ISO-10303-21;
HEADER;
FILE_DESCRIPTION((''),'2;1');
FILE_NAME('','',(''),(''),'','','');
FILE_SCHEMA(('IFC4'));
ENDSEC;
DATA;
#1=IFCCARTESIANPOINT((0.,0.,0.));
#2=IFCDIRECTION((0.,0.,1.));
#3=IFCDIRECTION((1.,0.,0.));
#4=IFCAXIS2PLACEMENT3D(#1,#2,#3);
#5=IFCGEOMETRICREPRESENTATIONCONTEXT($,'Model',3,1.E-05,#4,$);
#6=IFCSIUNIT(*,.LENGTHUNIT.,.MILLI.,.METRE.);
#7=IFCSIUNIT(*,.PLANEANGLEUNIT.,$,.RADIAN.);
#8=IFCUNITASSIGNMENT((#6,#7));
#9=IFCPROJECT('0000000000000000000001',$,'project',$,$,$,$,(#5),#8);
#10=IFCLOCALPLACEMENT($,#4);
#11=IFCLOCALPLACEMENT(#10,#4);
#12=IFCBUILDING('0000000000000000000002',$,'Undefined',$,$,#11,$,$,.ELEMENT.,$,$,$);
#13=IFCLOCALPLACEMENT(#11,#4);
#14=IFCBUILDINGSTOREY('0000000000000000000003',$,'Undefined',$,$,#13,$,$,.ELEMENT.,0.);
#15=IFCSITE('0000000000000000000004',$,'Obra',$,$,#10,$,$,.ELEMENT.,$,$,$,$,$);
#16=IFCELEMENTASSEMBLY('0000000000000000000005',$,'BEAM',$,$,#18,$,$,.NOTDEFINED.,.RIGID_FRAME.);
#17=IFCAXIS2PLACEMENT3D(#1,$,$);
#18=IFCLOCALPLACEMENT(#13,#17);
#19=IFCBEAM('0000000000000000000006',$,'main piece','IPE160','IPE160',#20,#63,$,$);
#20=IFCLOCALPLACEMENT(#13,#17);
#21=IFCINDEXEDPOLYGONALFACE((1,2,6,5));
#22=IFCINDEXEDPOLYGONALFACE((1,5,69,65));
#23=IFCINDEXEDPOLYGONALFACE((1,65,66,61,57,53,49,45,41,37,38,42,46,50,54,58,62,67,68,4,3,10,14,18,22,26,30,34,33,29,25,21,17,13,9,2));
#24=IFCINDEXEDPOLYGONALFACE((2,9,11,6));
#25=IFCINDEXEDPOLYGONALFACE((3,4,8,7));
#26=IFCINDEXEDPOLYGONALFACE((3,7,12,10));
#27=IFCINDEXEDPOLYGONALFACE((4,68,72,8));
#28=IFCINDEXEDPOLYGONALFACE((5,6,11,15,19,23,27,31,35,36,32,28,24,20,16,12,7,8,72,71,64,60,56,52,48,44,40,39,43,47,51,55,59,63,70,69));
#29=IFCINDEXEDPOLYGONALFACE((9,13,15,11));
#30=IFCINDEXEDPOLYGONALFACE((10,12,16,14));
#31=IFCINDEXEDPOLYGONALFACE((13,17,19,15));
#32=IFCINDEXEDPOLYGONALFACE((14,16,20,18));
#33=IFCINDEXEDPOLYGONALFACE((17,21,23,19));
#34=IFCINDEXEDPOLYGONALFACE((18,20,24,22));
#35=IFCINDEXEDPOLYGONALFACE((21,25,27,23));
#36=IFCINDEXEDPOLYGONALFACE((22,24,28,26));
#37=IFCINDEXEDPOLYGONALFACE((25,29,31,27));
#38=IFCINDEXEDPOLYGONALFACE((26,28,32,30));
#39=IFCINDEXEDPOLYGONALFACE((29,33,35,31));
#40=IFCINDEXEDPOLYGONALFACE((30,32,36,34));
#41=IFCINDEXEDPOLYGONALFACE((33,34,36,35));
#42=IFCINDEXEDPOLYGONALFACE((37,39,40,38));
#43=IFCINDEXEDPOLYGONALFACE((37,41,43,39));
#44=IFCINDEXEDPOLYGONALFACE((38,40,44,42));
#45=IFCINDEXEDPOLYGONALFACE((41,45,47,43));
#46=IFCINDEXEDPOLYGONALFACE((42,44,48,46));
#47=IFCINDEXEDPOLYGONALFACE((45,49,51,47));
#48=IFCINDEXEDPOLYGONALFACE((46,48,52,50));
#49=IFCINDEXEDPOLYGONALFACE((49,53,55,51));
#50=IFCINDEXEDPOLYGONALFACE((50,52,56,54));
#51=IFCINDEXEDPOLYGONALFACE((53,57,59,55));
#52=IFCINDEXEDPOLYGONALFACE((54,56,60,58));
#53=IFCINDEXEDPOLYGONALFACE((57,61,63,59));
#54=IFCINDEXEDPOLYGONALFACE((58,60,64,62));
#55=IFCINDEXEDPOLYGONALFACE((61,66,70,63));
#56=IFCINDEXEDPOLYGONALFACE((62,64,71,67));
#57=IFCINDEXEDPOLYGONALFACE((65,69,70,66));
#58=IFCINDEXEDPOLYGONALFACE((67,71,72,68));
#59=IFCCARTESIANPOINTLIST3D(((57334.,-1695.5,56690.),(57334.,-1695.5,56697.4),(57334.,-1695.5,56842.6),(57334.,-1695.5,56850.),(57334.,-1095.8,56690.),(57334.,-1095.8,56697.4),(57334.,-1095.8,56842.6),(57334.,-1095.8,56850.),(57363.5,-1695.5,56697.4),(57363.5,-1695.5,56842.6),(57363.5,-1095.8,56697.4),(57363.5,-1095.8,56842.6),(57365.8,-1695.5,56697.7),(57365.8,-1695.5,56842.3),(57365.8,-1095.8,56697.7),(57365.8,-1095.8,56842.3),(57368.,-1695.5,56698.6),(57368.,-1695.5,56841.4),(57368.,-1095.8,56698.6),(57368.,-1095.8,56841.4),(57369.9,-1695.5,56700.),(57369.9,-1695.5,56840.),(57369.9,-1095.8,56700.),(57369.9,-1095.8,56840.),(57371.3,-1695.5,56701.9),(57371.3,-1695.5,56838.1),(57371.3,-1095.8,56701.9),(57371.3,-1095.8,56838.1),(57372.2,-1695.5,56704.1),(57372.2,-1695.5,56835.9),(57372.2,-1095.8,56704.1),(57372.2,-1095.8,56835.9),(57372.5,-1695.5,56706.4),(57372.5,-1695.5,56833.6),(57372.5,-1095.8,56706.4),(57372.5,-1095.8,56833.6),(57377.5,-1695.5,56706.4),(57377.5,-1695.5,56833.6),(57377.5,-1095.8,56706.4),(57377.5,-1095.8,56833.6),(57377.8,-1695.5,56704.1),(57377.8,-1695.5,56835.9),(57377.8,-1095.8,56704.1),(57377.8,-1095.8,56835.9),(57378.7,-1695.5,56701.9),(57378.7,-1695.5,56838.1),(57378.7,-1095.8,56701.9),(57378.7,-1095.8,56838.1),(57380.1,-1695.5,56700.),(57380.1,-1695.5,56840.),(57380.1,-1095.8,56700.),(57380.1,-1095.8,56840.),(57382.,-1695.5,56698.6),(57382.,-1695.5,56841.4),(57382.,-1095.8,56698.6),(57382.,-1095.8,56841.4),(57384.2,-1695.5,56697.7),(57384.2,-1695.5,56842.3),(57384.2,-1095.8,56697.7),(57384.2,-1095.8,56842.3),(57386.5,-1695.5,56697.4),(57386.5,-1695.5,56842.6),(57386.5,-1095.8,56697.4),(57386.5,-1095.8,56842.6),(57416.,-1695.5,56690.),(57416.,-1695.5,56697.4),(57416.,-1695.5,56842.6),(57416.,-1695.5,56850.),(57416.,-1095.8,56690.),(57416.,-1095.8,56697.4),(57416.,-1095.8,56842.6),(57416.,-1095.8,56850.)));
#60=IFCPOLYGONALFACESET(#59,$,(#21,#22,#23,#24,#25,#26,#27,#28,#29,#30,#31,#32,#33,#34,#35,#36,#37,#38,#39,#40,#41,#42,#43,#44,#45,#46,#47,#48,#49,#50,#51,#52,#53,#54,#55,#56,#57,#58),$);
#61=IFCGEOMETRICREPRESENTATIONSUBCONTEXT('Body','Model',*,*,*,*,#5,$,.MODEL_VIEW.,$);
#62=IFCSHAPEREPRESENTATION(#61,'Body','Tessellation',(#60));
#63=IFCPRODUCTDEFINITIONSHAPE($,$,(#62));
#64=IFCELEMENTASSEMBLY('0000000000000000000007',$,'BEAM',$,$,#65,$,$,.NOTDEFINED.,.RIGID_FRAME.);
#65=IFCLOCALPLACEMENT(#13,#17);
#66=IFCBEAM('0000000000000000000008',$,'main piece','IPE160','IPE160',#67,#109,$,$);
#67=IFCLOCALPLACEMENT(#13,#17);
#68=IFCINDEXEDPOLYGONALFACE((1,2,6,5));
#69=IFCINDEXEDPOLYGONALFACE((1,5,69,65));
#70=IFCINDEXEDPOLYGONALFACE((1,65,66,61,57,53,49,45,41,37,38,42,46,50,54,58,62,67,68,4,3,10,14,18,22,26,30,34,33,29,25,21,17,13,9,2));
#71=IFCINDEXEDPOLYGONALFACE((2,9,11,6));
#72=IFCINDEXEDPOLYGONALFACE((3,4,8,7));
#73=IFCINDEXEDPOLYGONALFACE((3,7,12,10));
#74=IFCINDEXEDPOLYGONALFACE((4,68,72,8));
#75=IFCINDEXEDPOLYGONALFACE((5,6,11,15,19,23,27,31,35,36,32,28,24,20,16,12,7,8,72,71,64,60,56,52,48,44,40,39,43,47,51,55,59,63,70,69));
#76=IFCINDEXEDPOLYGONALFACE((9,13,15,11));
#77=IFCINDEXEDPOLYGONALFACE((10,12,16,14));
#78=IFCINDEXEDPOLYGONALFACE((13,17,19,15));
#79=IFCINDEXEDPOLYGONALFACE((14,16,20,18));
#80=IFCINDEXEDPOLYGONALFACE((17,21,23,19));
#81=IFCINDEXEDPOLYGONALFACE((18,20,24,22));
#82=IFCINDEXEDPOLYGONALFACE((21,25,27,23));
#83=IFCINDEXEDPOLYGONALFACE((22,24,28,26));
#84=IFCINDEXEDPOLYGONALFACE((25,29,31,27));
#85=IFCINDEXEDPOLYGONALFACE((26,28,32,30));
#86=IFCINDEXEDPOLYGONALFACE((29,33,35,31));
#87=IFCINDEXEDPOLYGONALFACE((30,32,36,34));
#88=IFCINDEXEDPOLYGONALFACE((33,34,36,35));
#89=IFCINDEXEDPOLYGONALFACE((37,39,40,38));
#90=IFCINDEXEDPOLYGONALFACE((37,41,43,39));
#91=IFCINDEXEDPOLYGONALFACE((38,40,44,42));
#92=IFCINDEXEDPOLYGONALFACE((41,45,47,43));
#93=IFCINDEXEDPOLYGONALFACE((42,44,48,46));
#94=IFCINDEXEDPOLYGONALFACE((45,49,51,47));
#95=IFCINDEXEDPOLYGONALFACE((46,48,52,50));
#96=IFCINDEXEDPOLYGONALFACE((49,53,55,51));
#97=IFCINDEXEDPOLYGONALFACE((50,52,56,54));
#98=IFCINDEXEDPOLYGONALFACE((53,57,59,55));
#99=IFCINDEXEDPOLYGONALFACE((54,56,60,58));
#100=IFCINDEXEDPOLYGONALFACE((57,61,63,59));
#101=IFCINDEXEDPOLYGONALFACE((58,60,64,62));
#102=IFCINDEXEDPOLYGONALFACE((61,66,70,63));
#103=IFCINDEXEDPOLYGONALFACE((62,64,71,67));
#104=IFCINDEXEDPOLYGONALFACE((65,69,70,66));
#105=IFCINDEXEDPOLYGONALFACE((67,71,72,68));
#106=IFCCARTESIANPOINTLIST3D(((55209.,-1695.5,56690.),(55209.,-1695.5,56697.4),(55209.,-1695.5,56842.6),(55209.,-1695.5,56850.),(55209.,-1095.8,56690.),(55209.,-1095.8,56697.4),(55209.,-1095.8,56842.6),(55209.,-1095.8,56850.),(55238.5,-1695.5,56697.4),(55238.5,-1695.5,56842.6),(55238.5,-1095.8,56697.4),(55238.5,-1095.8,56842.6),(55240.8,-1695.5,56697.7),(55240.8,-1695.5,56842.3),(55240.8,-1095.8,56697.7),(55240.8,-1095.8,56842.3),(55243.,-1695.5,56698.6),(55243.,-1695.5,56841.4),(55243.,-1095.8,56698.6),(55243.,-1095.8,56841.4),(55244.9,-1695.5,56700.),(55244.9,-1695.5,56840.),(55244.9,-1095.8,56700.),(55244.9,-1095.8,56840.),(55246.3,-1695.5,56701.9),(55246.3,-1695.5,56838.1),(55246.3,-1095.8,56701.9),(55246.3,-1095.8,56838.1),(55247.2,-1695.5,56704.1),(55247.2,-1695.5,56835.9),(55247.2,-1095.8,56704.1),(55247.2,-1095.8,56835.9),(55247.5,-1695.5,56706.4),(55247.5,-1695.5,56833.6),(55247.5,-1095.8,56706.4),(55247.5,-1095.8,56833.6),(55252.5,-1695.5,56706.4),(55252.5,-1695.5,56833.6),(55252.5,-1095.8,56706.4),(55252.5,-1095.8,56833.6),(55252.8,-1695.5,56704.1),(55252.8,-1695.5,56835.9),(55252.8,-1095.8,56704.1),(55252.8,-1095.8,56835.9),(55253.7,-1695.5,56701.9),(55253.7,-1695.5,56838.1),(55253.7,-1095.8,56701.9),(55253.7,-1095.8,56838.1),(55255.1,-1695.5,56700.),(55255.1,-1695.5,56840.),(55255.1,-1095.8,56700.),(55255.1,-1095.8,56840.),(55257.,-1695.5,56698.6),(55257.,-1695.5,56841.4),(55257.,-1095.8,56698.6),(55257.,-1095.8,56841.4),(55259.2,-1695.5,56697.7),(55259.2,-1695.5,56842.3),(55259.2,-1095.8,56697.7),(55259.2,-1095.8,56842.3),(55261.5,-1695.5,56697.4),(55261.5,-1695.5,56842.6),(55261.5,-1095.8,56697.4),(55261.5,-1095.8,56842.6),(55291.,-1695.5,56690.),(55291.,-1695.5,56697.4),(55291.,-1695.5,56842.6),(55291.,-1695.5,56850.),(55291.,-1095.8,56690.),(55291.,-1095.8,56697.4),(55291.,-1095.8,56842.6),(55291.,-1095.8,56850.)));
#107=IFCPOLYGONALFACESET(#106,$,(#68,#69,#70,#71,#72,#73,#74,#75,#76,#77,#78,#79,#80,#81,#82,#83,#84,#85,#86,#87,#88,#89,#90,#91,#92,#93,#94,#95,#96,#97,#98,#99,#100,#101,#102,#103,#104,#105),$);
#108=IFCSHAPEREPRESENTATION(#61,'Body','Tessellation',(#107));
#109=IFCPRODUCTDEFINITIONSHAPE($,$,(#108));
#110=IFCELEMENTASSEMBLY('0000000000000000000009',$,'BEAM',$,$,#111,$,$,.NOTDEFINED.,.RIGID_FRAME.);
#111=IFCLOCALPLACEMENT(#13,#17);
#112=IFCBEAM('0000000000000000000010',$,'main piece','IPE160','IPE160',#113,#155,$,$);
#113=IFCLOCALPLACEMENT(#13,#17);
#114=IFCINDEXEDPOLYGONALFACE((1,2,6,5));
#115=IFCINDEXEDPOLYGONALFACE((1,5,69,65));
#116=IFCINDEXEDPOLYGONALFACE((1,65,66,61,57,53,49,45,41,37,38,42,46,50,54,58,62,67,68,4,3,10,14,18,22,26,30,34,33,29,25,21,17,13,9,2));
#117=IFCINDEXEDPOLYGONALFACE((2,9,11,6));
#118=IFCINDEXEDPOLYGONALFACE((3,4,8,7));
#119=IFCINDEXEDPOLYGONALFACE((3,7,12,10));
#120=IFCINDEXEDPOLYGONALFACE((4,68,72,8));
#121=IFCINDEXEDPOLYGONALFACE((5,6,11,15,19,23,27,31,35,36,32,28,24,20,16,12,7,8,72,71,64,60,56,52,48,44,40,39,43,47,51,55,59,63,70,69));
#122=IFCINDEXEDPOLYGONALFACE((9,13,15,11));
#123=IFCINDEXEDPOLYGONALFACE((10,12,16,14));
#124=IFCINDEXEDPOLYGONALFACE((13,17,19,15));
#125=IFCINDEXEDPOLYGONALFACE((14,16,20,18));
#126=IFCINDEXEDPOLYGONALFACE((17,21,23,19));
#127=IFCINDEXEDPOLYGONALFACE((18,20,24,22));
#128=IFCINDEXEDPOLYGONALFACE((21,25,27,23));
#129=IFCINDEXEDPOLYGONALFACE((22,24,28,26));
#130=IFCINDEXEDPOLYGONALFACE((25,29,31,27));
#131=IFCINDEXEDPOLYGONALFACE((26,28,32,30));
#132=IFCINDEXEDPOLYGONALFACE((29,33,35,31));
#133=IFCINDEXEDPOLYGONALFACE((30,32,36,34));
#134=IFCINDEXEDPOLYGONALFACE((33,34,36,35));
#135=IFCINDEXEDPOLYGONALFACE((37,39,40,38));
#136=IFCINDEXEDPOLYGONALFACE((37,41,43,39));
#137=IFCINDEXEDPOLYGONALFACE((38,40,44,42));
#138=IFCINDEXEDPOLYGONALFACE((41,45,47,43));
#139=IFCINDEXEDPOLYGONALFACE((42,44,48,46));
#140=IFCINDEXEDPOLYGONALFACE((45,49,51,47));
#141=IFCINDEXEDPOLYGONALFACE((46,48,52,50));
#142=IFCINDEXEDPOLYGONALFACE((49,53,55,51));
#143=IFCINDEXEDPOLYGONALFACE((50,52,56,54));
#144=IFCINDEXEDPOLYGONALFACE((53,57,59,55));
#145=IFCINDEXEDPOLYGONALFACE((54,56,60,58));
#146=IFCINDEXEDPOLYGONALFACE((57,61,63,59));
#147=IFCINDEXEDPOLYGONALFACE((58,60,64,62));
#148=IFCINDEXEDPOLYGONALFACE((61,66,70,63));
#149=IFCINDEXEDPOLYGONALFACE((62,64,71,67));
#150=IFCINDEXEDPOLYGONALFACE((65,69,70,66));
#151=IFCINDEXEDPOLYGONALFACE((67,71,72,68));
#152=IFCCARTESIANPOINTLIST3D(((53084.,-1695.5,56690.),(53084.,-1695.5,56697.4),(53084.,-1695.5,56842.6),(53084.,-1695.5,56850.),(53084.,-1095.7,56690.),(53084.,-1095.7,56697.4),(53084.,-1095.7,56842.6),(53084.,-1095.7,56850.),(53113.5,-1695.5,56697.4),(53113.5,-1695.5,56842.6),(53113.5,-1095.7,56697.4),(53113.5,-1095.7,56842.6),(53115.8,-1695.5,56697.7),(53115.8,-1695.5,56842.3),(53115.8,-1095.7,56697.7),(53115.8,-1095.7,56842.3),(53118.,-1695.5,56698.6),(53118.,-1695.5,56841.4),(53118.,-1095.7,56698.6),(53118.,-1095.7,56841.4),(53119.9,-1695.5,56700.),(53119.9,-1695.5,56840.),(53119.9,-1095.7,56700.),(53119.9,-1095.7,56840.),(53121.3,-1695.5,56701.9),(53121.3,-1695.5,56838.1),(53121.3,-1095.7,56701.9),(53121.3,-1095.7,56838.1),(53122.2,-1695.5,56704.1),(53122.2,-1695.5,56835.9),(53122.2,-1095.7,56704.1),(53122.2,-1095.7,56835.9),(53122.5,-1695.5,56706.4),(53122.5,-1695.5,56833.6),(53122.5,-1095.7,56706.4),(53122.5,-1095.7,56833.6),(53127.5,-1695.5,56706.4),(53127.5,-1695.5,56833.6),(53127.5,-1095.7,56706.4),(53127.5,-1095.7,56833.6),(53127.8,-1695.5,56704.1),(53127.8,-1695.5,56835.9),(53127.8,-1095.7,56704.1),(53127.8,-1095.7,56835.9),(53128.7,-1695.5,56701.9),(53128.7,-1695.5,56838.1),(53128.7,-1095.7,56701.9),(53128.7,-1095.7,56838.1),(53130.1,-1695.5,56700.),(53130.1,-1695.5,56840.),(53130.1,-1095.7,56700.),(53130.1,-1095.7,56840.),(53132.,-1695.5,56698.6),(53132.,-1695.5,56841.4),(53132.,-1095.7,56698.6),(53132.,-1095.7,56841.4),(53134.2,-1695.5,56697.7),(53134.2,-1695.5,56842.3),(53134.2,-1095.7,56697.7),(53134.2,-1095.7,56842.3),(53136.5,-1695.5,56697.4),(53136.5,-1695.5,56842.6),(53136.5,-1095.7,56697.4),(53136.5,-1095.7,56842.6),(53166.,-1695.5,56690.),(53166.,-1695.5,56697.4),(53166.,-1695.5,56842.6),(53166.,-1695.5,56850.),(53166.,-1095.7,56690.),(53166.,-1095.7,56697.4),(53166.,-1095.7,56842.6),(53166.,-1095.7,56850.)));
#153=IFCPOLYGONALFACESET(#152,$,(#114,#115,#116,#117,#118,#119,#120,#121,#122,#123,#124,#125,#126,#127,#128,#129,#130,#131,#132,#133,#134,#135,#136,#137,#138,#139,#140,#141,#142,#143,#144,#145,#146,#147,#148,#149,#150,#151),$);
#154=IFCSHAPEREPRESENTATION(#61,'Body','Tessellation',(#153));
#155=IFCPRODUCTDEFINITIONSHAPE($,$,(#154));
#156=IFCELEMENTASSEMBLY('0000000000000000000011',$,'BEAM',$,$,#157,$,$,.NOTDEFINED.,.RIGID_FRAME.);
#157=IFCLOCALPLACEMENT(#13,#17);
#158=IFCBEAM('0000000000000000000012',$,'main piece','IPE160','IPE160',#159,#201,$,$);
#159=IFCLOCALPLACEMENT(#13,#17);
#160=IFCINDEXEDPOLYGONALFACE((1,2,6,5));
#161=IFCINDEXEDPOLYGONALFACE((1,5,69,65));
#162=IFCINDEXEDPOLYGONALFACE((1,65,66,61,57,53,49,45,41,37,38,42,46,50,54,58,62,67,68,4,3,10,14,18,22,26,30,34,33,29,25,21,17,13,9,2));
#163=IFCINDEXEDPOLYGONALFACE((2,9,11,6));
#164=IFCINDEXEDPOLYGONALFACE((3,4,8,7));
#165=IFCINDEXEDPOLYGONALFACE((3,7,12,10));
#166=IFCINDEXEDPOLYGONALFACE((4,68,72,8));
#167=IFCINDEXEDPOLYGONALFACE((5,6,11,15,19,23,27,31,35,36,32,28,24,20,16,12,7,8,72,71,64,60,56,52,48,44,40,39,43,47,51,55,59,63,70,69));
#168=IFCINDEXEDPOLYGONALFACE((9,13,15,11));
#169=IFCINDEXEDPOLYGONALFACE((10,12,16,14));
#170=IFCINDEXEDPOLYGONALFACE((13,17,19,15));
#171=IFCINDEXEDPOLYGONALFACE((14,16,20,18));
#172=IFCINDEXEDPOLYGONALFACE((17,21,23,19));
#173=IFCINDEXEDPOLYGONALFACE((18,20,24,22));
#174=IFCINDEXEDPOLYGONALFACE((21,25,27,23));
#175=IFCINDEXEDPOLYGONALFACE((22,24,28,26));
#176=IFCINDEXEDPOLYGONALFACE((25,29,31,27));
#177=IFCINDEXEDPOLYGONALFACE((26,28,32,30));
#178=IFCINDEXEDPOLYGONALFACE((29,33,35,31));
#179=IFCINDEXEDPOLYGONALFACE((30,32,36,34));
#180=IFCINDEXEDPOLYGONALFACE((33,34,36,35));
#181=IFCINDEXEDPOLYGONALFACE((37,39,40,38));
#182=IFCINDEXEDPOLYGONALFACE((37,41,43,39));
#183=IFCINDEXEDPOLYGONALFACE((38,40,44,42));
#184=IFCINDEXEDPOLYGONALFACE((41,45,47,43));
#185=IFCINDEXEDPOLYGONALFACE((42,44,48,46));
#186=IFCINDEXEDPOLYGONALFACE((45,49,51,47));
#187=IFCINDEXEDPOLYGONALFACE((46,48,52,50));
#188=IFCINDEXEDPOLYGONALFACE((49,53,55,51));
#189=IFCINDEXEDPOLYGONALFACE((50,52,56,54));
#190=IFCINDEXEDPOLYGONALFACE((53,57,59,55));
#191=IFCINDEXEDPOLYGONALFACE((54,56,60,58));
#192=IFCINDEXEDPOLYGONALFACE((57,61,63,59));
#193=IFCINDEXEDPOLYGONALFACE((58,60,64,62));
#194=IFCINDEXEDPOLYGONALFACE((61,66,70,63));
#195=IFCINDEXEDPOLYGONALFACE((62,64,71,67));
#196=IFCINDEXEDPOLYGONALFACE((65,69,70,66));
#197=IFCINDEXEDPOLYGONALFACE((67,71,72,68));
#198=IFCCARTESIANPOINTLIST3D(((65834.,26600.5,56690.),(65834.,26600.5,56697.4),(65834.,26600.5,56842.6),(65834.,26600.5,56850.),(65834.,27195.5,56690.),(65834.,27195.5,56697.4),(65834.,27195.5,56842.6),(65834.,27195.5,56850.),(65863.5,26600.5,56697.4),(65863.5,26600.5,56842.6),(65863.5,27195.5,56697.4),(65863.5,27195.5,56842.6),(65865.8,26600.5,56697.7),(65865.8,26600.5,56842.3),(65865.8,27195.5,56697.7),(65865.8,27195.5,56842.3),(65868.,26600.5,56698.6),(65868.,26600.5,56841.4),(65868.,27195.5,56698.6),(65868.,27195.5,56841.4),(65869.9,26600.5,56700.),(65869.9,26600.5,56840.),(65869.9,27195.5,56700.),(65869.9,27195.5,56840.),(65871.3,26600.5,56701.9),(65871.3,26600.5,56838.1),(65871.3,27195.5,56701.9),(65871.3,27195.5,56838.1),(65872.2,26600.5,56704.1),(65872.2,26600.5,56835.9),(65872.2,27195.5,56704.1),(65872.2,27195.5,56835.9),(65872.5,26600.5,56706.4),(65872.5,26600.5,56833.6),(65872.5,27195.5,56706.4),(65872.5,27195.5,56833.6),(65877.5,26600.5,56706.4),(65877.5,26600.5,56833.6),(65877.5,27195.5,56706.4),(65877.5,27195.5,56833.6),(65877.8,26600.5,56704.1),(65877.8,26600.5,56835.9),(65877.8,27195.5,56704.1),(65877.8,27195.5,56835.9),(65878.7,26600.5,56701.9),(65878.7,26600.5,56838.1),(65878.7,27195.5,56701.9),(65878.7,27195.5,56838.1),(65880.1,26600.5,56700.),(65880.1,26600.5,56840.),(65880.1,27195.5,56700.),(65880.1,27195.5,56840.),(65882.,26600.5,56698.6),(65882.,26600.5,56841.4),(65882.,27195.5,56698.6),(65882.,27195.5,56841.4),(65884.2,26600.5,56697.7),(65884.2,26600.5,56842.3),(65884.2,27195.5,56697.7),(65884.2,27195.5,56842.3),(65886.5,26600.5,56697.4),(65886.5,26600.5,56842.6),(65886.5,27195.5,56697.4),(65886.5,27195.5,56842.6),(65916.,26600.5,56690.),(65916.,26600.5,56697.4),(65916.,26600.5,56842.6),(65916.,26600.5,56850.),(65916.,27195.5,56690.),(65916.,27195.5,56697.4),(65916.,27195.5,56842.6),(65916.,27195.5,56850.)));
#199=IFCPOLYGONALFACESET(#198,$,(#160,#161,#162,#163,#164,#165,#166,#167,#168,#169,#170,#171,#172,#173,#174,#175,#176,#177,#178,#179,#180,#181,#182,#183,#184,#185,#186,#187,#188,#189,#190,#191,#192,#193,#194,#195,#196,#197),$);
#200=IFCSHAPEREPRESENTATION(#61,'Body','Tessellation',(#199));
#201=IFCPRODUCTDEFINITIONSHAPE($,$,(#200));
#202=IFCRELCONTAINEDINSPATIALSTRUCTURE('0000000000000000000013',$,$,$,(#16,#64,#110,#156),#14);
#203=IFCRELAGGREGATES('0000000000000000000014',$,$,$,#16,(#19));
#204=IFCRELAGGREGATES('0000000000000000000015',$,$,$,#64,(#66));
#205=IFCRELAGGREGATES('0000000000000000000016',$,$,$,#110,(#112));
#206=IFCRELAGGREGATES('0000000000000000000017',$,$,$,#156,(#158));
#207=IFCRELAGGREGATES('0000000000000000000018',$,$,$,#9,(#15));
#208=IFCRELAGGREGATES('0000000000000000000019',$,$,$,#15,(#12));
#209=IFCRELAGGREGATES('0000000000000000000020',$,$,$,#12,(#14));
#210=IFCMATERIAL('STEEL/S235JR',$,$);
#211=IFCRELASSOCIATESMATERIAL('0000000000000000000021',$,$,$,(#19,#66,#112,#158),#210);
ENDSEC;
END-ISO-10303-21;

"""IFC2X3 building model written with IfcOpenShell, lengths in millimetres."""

from ifc_helpers import new_model, si_unit, frame, origin_with_axes, origin_2d_with_axis, place, context, subcontext, project, spatial, i_section, extrude, material, element, aggregate, save


model = new_model("IFC2X3")

# Units and contexts
model_context = context("Model", 3, precision=1e-05, world=origin_with_axes())
body_context = subcontext(model_context, "Body", "Model", "MODEL_VIEW")
ifc_project = project(units=[si_unit("LENGTHUNIT", "METRE", prefix="MILLI"), si_unit("PLANEANGLEUNIT", "RADIAN")], contexts=[model_context])

# Site, building, storey
site_placement = place(None, origin_with_axes())
site = spatial("IfcSite", under=ifc_project, at=site_placement, Name="Obra", CompositionType="ELEMENT")
building_placement = place(site_placement, origin_with_axes())
building = spatial("IfcBuilding", under=site, at=building_placement, Name="Undefined", CompositionType="ELEMENT")
storey_placement = place(building_placement, origin_with_axes())
storey = spatial("IfcBuildingStorey", under=building, at=storey_placement, Name="Undefined", CompositionType="ELEMENT", Elevation=0.0)

# Element assemblies, beams
ifc_material_1 = material(Name="STEEL/S235JR")
assembly_1_placement = place(storey_placement, origin_with_axes())
assembly_1 = element("IfcElementAssembly", 1, at=assembly_1_placement, inside=storey, Name="BEAM", AssemblyPlace="NOTDEFINED", PredefinedType="RIGID_FRAME")
beam_1_placement = place(assembly_1_placement, frame((57375.0, -1095.8, 56770.0), z_axis=(0.0, 0.0, 1.0), x_axis=(0.0, -1.0, 0.0)))
beam_1 = element("IfcBeam", 2, at=beam_1_placement, material=ifc_material_1, Name="main piece", Description="IPE160", ObjectType="IPE160", context=body_context, shape_type="SweptSolid", body=[
    extrude(i_section(OverallWidth=82.0, OverallDepth=160.0, WebThickness=5.0, FlangeThickness=7.4, FilletRadius=9.0, at=origin_2d_with_axis()), frame((599.7, 0.0, 0.0), z_axis=(-1.0, 0.0, 0.0), x_axis=(0.0, -1.0, 0.0)), (0.0, 0.0, 1.0), 599.7),
])
aggregate(assembly_1, [beam_1])
assembly_2_placement = place(storey_placement, origin_with_axes())
assembly_2 = element("IfcElementAssembly", 3, at=assembly_2_placement, inside=storey, Name="BEAM", AssemblyPlace="NOTDEFINED", PredefinedType="RIGID_FRAME")
beam_2_placement = place(assembly_2_placement, frame((55250.0, -1095.8, 56770.0), z_axis=(0.0, 0.0, 1.0), x_axis=(0.0, -1.0, 0.0)))
beam_2 = element("IfcBeam", 4, at=beam_2_placement, material=ifc_material_1, Name="main piece", Description="IPE160", ObjectType="IPE160", context=body_context, shape_type="SweptSolid", body=[
    extrude(i_section(OverallWidth=82.0, OverallDepth=160.0, WebThickness=5.0, FlangeThickness=7.4, FilletRadius=9.0, at=origin_2d_with_axis()), frame((599.7, 0.0, 0.0), z_axis=(-1.0, 0.0, 0.0), x_axis=(0.0, -1.0, 0.0)), (0.0, 0.0, 1.0), 599.7),
])
aggregate(assembly_2, [beam_2])
assembly_3_placement = place(storey_placement, origin_with_axes())
assembly_3 = element("IfcElementAssembly", 5, at=assembly_3_placement, inside=storey, Name="BEAM", AssemblyPlace="NOTDEFINED", PredefinedType="RIGID_FRAME")
beam_3_placement = place(assembly_3_placement, frame((53125.0, -1095.7, 56770.0), z_axis=(0.0, 0.0, 1.0), x_axis=(0.0, -1.0, 0.0)))
beam_3 = element("IfcBeam", 6, at=beam_3_placement, material=ifc_material_1, Name="main piece", Description="IPE160", ObjectType="IPE160", context=body_context, shape_type="SweptSolid", body=[
    extrude(i_section(OverallWidth=82.0, OverallDepth=160.0, WebThickness=5.0, FlangeThickness=7.4, FilletRadius=9.0, at=origin_2d_with_axis()), frame((599.8, 0.0, 0.0), z_axis=(-1.0, 0.0, 0.0), x_axis=(0.0, -1.0, 0.0)), (0.0, 0.0, 1.0), 599.8),
])
aggregate(assembly_3, [beam_3])
assembly_4_placement = place(storey_placement, origin_with_axes())
assembly_4 = element("IfcElementAssembly", 7, at=assembly_4_placement, inside=storey, Name="BEAM", AssemblyPlace="NOTDEFINED", PredefinedType="RIGID_FRAME")
beam_4_placement = place(assembly_4_placement, frame((65875.0, 26600.5, 56770.0), z_axis=(0.0, 0.0, 1.0), x_axis=(0.0, 1.0, 0.0)))
beam_4 = element("IfcBeam", 8, at=beam_4_placement, material=ifc_material_1, Name="main piece", Description="IPE160", ObjectType="IPE160", context=body_context, shape_type="SweptSolid", body=[
    extrude(i_section(OverallWidth=82.0, OverallDepth=160.0, WebThickness=5.0, FlangeThickness=7.4, FilletRadius=9.0, at=origin_2d_with_axis()), frame((595.1, 0.0, 0.0), z_axis=(-1.0, 0.0, 0.0), x_axis=(0.0, -1.0, 0.0)), (0.0, 0.0, 1.0), 595.0),
])
aggregate(assembly_4, [beam_4])

save(model, "model.ifc")
